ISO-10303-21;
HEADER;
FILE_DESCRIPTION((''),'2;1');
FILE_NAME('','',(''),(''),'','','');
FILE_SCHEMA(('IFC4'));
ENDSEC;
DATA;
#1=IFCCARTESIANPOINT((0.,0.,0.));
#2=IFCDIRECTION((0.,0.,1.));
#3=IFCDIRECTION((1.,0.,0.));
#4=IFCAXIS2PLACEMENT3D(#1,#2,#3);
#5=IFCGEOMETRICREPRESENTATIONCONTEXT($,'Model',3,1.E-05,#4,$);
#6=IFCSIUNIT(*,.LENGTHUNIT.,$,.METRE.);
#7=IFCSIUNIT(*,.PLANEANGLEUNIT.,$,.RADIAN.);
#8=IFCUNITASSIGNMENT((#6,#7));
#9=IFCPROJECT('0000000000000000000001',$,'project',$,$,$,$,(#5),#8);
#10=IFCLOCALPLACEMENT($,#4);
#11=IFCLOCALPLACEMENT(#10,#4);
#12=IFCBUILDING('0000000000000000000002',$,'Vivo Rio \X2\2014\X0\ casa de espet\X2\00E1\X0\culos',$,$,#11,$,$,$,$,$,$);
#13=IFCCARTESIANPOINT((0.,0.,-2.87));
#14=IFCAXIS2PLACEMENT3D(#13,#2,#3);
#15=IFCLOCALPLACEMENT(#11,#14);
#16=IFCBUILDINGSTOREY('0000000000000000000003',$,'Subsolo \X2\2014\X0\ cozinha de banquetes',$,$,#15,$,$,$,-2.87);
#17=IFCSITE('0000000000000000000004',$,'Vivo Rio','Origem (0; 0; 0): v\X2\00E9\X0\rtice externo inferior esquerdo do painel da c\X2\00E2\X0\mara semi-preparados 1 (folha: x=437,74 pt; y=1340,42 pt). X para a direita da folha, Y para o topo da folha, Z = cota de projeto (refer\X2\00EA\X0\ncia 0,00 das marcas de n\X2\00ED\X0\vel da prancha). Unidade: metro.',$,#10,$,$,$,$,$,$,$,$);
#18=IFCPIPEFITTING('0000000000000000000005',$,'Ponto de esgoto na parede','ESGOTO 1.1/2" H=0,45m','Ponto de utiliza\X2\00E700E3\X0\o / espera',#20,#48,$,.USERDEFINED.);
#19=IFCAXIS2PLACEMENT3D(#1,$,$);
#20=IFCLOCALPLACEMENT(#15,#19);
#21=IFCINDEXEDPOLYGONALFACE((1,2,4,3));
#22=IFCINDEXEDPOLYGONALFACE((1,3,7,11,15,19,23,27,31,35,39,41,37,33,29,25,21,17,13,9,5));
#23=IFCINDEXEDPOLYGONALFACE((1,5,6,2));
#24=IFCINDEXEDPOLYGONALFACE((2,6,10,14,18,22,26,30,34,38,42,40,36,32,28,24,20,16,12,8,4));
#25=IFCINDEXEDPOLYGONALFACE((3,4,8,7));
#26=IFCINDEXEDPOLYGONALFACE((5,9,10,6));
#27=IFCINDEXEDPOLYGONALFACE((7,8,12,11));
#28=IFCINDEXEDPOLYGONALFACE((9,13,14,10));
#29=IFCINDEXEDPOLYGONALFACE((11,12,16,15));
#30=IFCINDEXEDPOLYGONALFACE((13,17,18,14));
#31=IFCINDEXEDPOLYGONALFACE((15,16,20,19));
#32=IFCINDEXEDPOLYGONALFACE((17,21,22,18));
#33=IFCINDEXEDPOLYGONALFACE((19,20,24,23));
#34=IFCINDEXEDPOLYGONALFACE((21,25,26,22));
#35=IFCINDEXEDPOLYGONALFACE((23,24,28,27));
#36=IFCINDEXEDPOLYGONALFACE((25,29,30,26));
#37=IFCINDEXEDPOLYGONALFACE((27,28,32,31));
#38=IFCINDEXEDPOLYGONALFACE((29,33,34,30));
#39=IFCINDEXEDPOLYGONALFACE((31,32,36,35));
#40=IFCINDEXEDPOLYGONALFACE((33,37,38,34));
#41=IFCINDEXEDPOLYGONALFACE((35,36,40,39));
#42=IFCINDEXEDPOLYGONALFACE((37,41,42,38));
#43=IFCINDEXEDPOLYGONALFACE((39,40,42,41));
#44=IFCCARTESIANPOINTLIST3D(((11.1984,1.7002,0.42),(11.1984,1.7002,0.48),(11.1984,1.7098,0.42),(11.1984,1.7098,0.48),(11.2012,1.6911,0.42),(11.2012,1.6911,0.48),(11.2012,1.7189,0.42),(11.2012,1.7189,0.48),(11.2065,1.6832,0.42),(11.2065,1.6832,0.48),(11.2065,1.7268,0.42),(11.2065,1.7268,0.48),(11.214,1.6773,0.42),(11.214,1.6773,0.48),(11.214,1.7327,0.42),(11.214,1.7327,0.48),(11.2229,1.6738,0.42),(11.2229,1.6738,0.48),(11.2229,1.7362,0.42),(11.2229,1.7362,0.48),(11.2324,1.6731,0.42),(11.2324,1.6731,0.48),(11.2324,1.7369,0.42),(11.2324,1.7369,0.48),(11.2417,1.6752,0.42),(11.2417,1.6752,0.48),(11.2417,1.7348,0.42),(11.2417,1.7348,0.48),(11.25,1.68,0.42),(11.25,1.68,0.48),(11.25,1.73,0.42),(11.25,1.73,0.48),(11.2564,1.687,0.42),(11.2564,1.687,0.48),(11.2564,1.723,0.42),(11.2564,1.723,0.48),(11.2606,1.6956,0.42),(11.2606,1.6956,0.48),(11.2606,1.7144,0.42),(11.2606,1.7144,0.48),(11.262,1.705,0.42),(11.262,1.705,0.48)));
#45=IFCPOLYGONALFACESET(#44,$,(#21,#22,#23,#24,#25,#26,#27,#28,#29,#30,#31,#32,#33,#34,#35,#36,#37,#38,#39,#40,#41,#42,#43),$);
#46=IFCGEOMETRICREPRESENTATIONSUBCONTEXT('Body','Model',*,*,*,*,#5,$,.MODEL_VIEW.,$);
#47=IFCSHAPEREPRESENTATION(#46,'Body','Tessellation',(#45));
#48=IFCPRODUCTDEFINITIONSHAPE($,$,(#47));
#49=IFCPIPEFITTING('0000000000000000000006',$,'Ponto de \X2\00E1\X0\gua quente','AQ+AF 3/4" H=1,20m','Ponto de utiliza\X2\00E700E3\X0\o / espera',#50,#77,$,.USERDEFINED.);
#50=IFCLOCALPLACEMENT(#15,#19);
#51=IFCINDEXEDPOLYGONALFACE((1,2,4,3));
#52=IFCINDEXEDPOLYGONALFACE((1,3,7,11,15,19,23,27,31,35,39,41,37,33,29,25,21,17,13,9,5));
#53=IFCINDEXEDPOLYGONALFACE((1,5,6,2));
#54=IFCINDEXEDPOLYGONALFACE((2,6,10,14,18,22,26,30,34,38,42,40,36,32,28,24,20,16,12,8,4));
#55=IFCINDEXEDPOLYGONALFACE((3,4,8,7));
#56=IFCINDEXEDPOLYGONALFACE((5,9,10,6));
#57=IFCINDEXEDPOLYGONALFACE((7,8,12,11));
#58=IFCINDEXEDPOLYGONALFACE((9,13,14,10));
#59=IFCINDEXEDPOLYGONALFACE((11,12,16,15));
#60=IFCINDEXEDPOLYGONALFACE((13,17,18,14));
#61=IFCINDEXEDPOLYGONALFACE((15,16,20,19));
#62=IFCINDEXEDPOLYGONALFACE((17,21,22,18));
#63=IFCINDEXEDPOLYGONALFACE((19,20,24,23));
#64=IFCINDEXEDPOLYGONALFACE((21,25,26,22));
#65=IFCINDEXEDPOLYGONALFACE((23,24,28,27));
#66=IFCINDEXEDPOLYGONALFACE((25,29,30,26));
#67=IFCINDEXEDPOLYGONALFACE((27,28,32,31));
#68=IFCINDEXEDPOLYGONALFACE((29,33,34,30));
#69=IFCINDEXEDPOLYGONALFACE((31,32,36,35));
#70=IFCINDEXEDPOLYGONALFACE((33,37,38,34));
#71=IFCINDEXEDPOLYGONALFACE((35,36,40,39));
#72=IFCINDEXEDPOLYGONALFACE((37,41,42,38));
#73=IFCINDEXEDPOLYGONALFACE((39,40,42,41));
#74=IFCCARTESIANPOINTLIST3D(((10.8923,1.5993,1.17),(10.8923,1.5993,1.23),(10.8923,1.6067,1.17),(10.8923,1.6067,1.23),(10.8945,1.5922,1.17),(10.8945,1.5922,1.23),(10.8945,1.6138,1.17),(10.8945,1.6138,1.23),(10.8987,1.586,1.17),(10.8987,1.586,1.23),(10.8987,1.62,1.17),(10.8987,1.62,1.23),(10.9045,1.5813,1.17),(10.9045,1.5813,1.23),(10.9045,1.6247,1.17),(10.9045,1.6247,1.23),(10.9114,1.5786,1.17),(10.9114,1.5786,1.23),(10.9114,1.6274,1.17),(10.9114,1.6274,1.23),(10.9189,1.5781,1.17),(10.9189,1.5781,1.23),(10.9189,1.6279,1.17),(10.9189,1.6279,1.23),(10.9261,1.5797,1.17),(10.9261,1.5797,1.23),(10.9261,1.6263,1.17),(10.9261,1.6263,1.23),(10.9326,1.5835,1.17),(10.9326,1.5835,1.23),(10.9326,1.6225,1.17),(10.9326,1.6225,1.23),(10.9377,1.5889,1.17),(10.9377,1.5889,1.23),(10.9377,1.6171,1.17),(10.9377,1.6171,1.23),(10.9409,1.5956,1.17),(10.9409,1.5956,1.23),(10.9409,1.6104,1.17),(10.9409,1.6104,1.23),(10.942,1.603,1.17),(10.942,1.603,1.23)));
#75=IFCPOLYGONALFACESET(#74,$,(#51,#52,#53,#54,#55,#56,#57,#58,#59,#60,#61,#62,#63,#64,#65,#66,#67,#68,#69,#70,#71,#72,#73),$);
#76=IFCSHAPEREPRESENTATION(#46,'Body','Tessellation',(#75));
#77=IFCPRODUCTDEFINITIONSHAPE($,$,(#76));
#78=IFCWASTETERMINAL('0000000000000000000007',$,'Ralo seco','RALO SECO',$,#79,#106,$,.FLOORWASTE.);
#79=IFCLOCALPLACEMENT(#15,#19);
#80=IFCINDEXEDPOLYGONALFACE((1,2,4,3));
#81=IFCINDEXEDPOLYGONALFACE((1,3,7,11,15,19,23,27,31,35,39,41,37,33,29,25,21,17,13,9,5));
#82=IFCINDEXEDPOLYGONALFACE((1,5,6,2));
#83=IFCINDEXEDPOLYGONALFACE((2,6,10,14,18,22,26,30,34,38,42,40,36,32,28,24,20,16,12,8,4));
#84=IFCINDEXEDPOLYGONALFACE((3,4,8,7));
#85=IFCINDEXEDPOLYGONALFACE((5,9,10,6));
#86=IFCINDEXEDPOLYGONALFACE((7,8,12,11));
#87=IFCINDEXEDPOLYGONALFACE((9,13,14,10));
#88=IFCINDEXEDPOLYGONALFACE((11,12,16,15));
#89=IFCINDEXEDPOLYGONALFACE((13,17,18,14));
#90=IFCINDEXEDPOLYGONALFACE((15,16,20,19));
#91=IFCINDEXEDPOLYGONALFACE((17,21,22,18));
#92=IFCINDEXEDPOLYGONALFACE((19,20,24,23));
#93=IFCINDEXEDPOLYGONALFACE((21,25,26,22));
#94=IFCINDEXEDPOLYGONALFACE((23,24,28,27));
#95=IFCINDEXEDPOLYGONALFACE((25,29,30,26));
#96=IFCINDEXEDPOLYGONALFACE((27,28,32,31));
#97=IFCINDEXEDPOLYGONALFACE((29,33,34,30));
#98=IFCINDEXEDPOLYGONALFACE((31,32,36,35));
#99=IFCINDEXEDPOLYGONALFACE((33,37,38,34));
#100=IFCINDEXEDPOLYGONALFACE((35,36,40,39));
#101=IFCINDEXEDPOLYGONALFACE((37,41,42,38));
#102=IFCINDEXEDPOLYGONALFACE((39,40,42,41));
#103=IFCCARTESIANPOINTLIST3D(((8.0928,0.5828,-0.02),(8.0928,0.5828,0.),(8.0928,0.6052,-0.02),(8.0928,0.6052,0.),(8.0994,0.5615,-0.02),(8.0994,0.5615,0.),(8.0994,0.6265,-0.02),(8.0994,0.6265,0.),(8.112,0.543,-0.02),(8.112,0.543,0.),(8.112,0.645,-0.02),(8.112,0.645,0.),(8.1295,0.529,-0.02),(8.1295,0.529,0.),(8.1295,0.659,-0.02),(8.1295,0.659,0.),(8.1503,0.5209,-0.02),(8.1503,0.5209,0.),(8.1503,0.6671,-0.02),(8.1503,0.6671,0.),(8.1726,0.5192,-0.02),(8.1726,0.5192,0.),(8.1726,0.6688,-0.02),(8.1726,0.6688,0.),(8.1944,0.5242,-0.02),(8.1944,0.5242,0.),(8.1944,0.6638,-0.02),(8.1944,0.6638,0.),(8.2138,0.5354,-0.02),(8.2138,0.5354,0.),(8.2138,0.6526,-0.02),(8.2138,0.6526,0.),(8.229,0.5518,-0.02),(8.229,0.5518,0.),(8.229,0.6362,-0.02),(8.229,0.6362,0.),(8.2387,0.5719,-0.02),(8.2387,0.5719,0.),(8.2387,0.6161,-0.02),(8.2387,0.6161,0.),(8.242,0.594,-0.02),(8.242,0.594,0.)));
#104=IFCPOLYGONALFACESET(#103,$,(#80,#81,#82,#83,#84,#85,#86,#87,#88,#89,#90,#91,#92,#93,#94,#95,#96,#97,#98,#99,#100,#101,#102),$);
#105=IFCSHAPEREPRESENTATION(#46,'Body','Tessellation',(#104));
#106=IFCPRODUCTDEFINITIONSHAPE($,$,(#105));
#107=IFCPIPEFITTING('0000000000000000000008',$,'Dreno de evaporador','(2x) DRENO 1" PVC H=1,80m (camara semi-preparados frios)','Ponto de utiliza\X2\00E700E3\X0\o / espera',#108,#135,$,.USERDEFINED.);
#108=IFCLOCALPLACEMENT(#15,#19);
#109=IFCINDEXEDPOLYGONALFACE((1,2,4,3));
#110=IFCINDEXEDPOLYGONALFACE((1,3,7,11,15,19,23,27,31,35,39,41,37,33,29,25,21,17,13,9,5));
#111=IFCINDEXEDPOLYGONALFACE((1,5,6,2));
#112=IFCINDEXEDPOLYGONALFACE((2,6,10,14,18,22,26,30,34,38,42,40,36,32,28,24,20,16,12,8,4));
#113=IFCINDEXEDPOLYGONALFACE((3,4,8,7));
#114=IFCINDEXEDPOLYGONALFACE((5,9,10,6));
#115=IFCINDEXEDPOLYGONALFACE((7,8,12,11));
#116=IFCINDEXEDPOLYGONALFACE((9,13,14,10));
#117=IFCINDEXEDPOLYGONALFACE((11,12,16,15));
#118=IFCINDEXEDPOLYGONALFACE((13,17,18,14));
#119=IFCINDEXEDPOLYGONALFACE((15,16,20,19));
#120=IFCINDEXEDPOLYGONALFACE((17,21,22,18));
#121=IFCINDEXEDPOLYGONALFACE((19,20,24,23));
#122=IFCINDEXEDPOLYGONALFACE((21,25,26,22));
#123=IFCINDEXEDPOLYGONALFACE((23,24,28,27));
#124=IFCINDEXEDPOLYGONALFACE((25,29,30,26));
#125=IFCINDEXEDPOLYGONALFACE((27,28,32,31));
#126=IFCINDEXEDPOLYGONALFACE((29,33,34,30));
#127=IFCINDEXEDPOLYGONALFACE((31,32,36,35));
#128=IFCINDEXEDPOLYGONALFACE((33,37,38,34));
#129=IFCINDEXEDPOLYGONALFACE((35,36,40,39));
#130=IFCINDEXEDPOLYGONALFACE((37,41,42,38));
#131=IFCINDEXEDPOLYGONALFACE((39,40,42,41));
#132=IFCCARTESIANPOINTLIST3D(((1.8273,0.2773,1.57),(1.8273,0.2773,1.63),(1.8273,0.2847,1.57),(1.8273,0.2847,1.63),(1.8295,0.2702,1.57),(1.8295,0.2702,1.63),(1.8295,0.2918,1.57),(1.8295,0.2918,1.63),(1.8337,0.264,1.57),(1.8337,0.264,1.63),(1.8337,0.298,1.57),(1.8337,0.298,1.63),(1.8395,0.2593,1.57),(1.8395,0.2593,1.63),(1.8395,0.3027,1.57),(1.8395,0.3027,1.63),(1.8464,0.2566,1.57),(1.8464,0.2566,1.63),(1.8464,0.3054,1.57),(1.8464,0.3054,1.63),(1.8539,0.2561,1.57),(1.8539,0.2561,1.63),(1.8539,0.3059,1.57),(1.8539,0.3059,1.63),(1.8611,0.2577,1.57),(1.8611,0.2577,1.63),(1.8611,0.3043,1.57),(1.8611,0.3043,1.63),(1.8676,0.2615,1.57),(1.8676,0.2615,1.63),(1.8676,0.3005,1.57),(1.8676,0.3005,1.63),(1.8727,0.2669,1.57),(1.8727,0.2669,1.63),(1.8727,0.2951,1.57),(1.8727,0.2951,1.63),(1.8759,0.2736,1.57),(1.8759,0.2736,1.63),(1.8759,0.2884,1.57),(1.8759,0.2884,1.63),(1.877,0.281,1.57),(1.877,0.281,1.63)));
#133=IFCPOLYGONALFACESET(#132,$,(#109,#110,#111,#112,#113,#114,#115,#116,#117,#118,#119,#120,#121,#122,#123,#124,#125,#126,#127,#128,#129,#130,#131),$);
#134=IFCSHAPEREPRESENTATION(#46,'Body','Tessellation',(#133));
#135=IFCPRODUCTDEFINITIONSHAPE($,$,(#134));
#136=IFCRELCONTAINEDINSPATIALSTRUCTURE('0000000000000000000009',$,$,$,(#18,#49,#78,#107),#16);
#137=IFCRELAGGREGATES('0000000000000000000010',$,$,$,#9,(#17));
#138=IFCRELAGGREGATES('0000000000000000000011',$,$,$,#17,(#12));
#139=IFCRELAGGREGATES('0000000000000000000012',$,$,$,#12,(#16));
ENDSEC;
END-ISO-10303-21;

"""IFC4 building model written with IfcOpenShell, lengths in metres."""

from ifc_helpers import new_model, si_unit, frame, origin_with_axes, origin_2d, place, context, subcontext, project, spatial, circle, extrude, element, save


model = new_model("IFC4")

# Units and contexts
model_context = context("Model", 3, precision=1e-05, world=origin_with_axes())
body_context = subcontext(model_context, "Body", "Model", "MODEL_VIEW")
ifc_project = project(units=[si_unit("LENGTHUNIT", "METRE"), si_unit("PLANEANGLEUNIT", "RADIAN")], contexts=[model_context])

# Site, building, storey
site_placement = place(None, origin_with_axes())
site = spatial("IfcSite", under=ifc_project, at=site_placement, Name="Vivo Rio", Description="Origem (0; 0; 0): vértice externo inferior esquerdo do painel da câmara semi-preparados 1 (folha: x=437,74 pt; y=1340,42 pt). X para a direita da folha, Y para o topo da folha, Z = cota de projeto (referência 0,00 das marcas de nível da prancha). Unidade: metro.")
building_placement = place(site_placement, origin_with_axes())
building = spatial("IfcBuilding", under=site, at=building_placement, Name="Vivo Rio — casa de espetáculos")
storey_placement = place(building_placement, frame((0.0, 0.0, -2.87), z_axis=(0.0, 0.0, 1.0), x_axis=(1.0, 0.0, 0.0)))
storey = spatial("IfcBuildingStorey", under=building, at=storey_placement, Name="Subsolo — cozinha de banquetes", Elevation=-2.87)

# Pipe fittings
pipe_fitting_1_placement = place(storey_placement, origin_with_axes())
element("IfcPipeFitting", 1, at=pipe_fitting_1_placement, inside=storey, Name="Ponto de esgoto na parede", Description="ESGOTO 1.1/2\" H=0,45m", ObjectType="Ponto de utilização / espera", PredefinedType="USERDEFINED", context=body_context, shape_type="SweptSolid", body=[
    extrude(circle(Radius=0.032, at=origin_2d()), frame((11.23, 1.705, 0.42), z_axis=(0.0, 0.0, 1.0), x_axis=(1.0, 0.0, 0.0)), (0.0, 0.0, 1.0), 0.06),
])
pipe_fitting_2_placement = place(storey_placement, origin_with_axes())
element("IfcPipeFitting", 2, at=pipe_fitting_2_placement, inside=storey, Name="Ponto de água quente", Description="AQ+AF 3/4\" H=1,20m", ObjectType="Ponto de utilização / espera", PredefinedType="USERDEFINED", context=body_context, shape_type="SweptSolid", body=[
    extrude(circle(Radius=0.025, at=origin_2d()), frame((10.917, 1.603, 1.17), z_axis=(0.0, 0.0, 1.0), x_axis=(1.0, 0.0, 0.0)), (0.0, 0.0, 1.0), 0.06),
])

# Waste terminal
waste_terminal_1_placement = place(storey_placement, origin_with_axes())
element("IfcWasteTerminal", 3, at=waste_terminal_1_placement, inside=storey, Name="Ralo seco", Description="RALO SECO", PredefinedType="FLOORWASTE", context=body_context, shape_type="SweptSolid", body=[
    extrude(circle(Radius=0.075, at=origin_2d()), frame((8.167, 0.594, -0.02), z_axis=(0.0, 0.0, 1.0), x_axis=(1.0, 0.0, 0.0)), (0.0, 0.0, 1.0), 0.02),
])

# Pipe fitting
pipe_fitting_3_placement = place(storey_placement, origin_with_axes())
element("IfcPipeFitting", 4, at=pipe_fitting_3_placement, inside=storey, Name="Dreno de evaporador", Description="(2x) DRENO 1\" PVC H=1,80m (camara semi-preparados frios)", ObjectType="Ponto de utilização / espera", PredefinedType="USERDEFINED", context=body_context, shape_type="SweptSolid", body=[
    extrude(circle(Radius=0.025, at=origin_2d()), frame((1.852, 0.281, 1.57), z_axis=(0.0, 0.0, 1.0), x_axis=(1.0, 0.0, 0.0)), (0.0, 0.0, 1.0), 0.06),
])

save(model, "model.ifc")
